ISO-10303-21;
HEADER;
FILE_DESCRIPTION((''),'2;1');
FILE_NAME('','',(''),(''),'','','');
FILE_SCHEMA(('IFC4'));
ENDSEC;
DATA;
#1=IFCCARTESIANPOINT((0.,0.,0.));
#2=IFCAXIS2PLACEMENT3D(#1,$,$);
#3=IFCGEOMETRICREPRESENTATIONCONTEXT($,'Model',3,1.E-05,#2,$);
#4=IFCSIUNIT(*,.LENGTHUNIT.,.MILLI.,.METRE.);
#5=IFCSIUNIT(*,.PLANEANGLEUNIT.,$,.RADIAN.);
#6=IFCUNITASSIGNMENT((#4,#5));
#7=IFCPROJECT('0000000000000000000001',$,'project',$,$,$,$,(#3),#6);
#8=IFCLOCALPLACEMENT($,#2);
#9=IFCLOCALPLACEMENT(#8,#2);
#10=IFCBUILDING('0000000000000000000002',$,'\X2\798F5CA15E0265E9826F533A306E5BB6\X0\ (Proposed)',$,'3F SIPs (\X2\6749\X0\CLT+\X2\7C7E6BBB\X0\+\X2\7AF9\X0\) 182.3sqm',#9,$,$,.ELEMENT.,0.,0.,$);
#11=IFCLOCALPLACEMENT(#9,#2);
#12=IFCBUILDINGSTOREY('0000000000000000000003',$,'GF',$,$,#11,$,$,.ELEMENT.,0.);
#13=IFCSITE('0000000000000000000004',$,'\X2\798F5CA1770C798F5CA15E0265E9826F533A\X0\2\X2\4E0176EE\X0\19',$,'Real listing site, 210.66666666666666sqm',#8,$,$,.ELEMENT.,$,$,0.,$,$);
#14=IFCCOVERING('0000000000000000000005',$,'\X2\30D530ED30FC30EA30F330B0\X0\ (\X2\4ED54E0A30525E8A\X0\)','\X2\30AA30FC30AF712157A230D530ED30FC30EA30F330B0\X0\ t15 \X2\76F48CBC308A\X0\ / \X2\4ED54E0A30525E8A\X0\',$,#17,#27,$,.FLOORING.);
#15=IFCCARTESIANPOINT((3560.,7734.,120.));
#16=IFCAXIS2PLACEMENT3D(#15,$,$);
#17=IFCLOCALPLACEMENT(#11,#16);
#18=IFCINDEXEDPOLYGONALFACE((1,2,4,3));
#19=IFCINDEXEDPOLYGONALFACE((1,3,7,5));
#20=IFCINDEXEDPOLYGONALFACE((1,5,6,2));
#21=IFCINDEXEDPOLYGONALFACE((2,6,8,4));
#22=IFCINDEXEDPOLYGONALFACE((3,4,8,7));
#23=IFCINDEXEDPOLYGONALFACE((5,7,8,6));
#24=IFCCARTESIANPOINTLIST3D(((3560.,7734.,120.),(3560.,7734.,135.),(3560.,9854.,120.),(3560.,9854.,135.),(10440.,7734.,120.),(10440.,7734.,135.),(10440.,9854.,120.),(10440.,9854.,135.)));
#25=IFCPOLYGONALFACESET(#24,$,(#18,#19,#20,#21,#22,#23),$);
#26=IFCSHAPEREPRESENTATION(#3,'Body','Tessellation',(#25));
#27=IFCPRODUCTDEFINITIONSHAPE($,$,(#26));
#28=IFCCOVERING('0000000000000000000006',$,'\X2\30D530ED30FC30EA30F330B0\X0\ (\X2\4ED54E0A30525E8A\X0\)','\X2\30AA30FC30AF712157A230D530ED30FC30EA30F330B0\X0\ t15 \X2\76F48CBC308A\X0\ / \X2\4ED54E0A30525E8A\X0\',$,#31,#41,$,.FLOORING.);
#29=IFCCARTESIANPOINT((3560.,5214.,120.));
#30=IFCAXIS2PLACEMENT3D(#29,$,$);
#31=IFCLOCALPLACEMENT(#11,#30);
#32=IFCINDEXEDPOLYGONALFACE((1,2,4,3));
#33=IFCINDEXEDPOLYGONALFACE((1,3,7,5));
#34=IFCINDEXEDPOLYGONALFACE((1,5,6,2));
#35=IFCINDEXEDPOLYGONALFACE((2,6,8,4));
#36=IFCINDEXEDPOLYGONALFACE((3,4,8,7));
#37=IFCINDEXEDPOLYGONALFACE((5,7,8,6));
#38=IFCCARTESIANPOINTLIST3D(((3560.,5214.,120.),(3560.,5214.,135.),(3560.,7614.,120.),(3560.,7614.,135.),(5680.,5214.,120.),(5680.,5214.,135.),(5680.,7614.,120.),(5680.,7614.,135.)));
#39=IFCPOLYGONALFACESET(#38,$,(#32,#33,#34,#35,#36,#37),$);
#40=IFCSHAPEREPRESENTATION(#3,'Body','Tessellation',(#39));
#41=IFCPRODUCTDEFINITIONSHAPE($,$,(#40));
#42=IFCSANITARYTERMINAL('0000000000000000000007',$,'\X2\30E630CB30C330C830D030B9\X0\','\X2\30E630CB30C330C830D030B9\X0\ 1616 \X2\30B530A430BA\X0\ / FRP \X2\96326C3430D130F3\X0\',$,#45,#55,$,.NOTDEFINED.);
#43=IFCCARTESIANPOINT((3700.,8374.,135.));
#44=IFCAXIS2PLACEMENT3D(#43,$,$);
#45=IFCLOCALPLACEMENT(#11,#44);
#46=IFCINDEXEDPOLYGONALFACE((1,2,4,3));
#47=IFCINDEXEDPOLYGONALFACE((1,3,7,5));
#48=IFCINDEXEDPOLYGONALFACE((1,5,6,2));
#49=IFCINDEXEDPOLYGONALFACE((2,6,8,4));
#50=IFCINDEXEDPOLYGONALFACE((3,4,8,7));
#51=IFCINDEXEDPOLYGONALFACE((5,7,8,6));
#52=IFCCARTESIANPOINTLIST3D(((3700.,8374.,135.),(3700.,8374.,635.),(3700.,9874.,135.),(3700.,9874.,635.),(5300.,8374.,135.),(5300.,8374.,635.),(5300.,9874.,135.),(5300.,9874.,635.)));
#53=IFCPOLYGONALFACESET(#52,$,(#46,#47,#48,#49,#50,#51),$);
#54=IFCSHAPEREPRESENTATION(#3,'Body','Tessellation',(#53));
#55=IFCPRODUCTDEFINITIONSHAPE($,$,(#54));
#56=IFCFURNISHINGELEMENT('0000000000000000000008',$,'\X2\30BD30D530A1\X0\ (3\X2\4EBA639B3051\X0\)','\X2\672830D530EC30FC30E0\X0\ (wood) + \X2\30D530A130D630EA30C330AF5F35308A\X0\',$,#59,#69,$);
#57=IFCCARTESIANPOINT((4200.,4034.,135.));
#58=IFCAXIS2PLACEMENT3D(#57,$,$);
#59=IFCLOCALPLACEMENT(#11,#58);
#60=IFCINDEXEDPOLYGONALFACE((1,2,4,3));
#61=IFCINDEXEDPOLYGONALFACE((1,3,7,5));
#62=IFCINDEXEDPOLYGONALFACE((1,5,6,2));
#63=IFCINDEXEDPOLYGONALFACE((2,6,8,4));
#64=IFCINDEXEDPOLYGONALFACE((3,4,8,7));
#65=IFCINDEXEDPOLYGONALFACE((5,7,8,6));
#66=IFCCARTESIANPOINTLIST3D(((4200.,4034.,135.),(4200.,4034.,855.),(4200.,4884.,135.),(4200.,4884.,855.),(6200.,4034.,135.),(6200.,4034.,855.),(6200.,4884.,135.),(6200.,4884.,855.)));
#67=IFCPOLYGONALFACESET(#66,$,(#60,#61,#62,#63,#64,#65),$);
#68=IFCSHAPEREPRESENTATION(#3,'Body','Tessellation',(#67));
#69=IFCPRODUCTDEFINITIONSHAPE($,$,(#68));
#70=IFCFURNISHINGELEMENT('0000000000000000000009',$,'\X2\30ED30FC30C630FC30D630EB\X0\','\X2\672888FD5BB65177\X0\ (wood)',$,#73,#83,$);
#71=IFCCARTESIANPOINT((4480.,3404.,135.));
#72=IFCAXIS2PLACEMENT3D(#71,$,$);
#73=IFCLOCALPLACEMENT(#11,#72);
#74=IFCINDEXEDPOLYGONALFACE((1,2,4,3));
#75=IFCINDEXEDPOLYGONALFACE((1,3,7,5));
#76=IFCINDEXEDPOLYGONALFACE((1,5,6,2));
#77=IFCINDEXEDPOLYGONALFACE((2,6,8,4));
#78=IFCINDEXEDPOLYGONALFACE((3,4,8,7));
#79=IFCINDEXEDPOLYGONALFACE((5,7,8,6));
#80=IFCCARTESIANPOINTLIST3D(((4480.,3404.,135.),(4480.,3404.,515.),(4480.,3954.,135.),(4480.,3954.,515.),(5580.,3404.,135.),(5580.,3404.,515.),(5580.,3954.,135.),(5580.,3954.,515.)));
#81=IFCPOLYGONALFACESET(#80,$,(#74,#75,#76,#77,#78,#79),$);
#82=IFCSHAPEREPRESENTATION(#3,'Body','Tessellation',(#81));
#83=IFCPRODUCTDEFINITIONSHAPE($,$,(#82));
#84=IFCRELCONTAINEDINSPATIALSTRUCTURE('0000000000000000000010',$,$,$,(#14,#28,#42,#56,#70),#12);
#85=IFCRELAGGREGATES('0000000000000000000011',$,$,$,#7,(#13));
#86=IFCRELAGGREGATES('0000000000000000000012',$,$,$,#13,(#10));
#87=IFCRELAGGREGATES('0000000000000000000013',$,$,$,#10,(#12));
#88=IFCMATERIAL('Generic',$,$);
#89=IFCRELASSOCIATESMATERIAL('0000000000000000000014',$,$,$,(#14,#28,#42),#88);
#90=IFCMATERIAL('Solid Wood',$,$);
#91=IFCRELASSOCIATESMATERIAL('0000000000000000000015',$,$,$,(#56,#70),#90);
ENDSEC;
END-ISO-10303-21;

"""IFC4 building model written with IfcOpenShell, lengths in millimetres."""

from ifc_helpers import new_model, si_unit, frame, frame_2d, origin, place, context, project, spatial, rectangle, extrude, material, element, save


model = new_model("IFC4")

# Units and contexts
model_context = context("Model", 3, precision=1e-05, world=origin())
ifc_project = project(units=[si_unit("LENGTHUNIT", "METRE", prefix="MILLI"), si_unit("PLANEANGLEUNIT", "RADIAN")], contexts=[model_context])

# Site, building, storey
site_placement = place(None, origin())
site = spatial("IfcSite", under=ifc_project, at=site_placement, Name="福岡県福岡市早良区2丁目19", ObjectType="Real listing site, 210.66666666666666sqm", CompositionType="ELEMENT", RefElevation=0.0)
building_placement = place(site_placement, origin())
building = spatial("IfcBuilding", under=site, at=building_placement, Name="福岡市早良区の家 (Proposed)", ObjectType="3F SIPs (杉CLT+籾殻+竹) 182.3sqm", CompositionType="ELEMENT", ElevationOfRefHeight=0.0, ElevationOfTerrain=0.0)
storey_placement = place(building_placement, origin())
storey = spatial("IfcBuildingStorey", under=building, at=storey_placement, Name="GF", CompositionType="ELEMENT", Elevation=0.0)

# Shared definitions
ifc_material_1 = material(Name="Solid Wood")

# Coverings
ifc_material_2 = material(Name="Generic")
covering_1_placement = place(storey_placement, frame((3560.0, 7734.0, 120.0)))
element("IfcCovering", 1, at=covering_1_placement, inside=storey, material=ifc_material_2, Name="フローリング (仕上げ床)", Description="オーク無垢フローリング t15 直貼り / 仕上げ床", PredefinedType="FLOORING", context=model_context, shape_type="SweptSolid", body=[
    extrude(rectangle(XDim=6880.0, YDim=2120.0, at=frame_2d((3440.0, 1060.0))), frame((3560.0, 7734.0, 120.0)), (0.0, 0.0, 1.0), 15.0),
])
covering_2_placement = place(storey_placement, frame((3560.0, 5214.0, 120.0)))
element("IfcCovering", 2, at=covering_2_placement, inside=storey, material=ifc_material_2, Name="フローリング (仕上げ床)", Description="オーク無垢フローリング t15 直貼り / 仕上げ床", PredefinedType="FLOORING", context=model_context, shape_type="SweptSolid", body=[
    extrude(rectangle(XDim=2120.0, YDim=2400.0, at=frame_2d((1060.0, 1200.0))), frame((3560.0, 5214.0, 120.0)), (0.0, 0.0, 1.0), 15.0),
])

# Sanitary terminal
sanitary_terminal_placement = place(storey_placement, frame((3700.0, 8374.0, 135.0)))
element("IfcSanitaryTerminal", 3, at=sanitary_terminal_placement, inside=storey, material=ifc_material_2, Name="ユニットバス", Description="ユニットバス 1616 サイズ / FRP 防水パン", PredefinedType="NOTDEFINED", context=model_context, shape_type="SweptSolid", body=[
    extrude(rectangle(XDim=1600.0, YDim=1500.0, at=frame_2d((800.0, 750.0))), frame((3700.0, 8374.0, 135.0)), (0.0, 0.0, 1.0), 500.0),
])

# Furnishing elements
furnishing_1_placement = place(storey_placement, frame((4200.0, 4034.0, 135.0)))
element("IfcFurnishingElement", 4, at=furnishing_1_placement, inside=storey, material=ifc_material_1, Name="ソファ (3人掛け)", Description="木フレーム (wood) + ファブリック張り", context=model_context, shape_type="SweptSolid", body=[
    extrude(rectangle(XDim=2000.0, YDim=850.0, at=frame_2d((1000.0, 425.0))), frame((4200.0, 4034.0, 135.0)), (0.0, 0.0, 1.0), 720.0),
])
furnishing_2_placement = place(storey_placement, frame((4480.0, 3404.0, 135.0)))
element("IfcFurnishingElement", 5, at=furnishing_2_placement, inside=storey, material=ifc_material_1, Name="ローテーブル", Description="木製家具 (wood)", context=model_context, shape_type="SweptSolid", body=[
    extrude(rectangle(XDim=1100.0, YDim=550.0, at=frame_2d((550.0, 275.0))), frame((4480.0, 3404.0, 135.0)), (0.0, 0.0, 1.0), 380.0),
])

save(model, "model.ifc")
